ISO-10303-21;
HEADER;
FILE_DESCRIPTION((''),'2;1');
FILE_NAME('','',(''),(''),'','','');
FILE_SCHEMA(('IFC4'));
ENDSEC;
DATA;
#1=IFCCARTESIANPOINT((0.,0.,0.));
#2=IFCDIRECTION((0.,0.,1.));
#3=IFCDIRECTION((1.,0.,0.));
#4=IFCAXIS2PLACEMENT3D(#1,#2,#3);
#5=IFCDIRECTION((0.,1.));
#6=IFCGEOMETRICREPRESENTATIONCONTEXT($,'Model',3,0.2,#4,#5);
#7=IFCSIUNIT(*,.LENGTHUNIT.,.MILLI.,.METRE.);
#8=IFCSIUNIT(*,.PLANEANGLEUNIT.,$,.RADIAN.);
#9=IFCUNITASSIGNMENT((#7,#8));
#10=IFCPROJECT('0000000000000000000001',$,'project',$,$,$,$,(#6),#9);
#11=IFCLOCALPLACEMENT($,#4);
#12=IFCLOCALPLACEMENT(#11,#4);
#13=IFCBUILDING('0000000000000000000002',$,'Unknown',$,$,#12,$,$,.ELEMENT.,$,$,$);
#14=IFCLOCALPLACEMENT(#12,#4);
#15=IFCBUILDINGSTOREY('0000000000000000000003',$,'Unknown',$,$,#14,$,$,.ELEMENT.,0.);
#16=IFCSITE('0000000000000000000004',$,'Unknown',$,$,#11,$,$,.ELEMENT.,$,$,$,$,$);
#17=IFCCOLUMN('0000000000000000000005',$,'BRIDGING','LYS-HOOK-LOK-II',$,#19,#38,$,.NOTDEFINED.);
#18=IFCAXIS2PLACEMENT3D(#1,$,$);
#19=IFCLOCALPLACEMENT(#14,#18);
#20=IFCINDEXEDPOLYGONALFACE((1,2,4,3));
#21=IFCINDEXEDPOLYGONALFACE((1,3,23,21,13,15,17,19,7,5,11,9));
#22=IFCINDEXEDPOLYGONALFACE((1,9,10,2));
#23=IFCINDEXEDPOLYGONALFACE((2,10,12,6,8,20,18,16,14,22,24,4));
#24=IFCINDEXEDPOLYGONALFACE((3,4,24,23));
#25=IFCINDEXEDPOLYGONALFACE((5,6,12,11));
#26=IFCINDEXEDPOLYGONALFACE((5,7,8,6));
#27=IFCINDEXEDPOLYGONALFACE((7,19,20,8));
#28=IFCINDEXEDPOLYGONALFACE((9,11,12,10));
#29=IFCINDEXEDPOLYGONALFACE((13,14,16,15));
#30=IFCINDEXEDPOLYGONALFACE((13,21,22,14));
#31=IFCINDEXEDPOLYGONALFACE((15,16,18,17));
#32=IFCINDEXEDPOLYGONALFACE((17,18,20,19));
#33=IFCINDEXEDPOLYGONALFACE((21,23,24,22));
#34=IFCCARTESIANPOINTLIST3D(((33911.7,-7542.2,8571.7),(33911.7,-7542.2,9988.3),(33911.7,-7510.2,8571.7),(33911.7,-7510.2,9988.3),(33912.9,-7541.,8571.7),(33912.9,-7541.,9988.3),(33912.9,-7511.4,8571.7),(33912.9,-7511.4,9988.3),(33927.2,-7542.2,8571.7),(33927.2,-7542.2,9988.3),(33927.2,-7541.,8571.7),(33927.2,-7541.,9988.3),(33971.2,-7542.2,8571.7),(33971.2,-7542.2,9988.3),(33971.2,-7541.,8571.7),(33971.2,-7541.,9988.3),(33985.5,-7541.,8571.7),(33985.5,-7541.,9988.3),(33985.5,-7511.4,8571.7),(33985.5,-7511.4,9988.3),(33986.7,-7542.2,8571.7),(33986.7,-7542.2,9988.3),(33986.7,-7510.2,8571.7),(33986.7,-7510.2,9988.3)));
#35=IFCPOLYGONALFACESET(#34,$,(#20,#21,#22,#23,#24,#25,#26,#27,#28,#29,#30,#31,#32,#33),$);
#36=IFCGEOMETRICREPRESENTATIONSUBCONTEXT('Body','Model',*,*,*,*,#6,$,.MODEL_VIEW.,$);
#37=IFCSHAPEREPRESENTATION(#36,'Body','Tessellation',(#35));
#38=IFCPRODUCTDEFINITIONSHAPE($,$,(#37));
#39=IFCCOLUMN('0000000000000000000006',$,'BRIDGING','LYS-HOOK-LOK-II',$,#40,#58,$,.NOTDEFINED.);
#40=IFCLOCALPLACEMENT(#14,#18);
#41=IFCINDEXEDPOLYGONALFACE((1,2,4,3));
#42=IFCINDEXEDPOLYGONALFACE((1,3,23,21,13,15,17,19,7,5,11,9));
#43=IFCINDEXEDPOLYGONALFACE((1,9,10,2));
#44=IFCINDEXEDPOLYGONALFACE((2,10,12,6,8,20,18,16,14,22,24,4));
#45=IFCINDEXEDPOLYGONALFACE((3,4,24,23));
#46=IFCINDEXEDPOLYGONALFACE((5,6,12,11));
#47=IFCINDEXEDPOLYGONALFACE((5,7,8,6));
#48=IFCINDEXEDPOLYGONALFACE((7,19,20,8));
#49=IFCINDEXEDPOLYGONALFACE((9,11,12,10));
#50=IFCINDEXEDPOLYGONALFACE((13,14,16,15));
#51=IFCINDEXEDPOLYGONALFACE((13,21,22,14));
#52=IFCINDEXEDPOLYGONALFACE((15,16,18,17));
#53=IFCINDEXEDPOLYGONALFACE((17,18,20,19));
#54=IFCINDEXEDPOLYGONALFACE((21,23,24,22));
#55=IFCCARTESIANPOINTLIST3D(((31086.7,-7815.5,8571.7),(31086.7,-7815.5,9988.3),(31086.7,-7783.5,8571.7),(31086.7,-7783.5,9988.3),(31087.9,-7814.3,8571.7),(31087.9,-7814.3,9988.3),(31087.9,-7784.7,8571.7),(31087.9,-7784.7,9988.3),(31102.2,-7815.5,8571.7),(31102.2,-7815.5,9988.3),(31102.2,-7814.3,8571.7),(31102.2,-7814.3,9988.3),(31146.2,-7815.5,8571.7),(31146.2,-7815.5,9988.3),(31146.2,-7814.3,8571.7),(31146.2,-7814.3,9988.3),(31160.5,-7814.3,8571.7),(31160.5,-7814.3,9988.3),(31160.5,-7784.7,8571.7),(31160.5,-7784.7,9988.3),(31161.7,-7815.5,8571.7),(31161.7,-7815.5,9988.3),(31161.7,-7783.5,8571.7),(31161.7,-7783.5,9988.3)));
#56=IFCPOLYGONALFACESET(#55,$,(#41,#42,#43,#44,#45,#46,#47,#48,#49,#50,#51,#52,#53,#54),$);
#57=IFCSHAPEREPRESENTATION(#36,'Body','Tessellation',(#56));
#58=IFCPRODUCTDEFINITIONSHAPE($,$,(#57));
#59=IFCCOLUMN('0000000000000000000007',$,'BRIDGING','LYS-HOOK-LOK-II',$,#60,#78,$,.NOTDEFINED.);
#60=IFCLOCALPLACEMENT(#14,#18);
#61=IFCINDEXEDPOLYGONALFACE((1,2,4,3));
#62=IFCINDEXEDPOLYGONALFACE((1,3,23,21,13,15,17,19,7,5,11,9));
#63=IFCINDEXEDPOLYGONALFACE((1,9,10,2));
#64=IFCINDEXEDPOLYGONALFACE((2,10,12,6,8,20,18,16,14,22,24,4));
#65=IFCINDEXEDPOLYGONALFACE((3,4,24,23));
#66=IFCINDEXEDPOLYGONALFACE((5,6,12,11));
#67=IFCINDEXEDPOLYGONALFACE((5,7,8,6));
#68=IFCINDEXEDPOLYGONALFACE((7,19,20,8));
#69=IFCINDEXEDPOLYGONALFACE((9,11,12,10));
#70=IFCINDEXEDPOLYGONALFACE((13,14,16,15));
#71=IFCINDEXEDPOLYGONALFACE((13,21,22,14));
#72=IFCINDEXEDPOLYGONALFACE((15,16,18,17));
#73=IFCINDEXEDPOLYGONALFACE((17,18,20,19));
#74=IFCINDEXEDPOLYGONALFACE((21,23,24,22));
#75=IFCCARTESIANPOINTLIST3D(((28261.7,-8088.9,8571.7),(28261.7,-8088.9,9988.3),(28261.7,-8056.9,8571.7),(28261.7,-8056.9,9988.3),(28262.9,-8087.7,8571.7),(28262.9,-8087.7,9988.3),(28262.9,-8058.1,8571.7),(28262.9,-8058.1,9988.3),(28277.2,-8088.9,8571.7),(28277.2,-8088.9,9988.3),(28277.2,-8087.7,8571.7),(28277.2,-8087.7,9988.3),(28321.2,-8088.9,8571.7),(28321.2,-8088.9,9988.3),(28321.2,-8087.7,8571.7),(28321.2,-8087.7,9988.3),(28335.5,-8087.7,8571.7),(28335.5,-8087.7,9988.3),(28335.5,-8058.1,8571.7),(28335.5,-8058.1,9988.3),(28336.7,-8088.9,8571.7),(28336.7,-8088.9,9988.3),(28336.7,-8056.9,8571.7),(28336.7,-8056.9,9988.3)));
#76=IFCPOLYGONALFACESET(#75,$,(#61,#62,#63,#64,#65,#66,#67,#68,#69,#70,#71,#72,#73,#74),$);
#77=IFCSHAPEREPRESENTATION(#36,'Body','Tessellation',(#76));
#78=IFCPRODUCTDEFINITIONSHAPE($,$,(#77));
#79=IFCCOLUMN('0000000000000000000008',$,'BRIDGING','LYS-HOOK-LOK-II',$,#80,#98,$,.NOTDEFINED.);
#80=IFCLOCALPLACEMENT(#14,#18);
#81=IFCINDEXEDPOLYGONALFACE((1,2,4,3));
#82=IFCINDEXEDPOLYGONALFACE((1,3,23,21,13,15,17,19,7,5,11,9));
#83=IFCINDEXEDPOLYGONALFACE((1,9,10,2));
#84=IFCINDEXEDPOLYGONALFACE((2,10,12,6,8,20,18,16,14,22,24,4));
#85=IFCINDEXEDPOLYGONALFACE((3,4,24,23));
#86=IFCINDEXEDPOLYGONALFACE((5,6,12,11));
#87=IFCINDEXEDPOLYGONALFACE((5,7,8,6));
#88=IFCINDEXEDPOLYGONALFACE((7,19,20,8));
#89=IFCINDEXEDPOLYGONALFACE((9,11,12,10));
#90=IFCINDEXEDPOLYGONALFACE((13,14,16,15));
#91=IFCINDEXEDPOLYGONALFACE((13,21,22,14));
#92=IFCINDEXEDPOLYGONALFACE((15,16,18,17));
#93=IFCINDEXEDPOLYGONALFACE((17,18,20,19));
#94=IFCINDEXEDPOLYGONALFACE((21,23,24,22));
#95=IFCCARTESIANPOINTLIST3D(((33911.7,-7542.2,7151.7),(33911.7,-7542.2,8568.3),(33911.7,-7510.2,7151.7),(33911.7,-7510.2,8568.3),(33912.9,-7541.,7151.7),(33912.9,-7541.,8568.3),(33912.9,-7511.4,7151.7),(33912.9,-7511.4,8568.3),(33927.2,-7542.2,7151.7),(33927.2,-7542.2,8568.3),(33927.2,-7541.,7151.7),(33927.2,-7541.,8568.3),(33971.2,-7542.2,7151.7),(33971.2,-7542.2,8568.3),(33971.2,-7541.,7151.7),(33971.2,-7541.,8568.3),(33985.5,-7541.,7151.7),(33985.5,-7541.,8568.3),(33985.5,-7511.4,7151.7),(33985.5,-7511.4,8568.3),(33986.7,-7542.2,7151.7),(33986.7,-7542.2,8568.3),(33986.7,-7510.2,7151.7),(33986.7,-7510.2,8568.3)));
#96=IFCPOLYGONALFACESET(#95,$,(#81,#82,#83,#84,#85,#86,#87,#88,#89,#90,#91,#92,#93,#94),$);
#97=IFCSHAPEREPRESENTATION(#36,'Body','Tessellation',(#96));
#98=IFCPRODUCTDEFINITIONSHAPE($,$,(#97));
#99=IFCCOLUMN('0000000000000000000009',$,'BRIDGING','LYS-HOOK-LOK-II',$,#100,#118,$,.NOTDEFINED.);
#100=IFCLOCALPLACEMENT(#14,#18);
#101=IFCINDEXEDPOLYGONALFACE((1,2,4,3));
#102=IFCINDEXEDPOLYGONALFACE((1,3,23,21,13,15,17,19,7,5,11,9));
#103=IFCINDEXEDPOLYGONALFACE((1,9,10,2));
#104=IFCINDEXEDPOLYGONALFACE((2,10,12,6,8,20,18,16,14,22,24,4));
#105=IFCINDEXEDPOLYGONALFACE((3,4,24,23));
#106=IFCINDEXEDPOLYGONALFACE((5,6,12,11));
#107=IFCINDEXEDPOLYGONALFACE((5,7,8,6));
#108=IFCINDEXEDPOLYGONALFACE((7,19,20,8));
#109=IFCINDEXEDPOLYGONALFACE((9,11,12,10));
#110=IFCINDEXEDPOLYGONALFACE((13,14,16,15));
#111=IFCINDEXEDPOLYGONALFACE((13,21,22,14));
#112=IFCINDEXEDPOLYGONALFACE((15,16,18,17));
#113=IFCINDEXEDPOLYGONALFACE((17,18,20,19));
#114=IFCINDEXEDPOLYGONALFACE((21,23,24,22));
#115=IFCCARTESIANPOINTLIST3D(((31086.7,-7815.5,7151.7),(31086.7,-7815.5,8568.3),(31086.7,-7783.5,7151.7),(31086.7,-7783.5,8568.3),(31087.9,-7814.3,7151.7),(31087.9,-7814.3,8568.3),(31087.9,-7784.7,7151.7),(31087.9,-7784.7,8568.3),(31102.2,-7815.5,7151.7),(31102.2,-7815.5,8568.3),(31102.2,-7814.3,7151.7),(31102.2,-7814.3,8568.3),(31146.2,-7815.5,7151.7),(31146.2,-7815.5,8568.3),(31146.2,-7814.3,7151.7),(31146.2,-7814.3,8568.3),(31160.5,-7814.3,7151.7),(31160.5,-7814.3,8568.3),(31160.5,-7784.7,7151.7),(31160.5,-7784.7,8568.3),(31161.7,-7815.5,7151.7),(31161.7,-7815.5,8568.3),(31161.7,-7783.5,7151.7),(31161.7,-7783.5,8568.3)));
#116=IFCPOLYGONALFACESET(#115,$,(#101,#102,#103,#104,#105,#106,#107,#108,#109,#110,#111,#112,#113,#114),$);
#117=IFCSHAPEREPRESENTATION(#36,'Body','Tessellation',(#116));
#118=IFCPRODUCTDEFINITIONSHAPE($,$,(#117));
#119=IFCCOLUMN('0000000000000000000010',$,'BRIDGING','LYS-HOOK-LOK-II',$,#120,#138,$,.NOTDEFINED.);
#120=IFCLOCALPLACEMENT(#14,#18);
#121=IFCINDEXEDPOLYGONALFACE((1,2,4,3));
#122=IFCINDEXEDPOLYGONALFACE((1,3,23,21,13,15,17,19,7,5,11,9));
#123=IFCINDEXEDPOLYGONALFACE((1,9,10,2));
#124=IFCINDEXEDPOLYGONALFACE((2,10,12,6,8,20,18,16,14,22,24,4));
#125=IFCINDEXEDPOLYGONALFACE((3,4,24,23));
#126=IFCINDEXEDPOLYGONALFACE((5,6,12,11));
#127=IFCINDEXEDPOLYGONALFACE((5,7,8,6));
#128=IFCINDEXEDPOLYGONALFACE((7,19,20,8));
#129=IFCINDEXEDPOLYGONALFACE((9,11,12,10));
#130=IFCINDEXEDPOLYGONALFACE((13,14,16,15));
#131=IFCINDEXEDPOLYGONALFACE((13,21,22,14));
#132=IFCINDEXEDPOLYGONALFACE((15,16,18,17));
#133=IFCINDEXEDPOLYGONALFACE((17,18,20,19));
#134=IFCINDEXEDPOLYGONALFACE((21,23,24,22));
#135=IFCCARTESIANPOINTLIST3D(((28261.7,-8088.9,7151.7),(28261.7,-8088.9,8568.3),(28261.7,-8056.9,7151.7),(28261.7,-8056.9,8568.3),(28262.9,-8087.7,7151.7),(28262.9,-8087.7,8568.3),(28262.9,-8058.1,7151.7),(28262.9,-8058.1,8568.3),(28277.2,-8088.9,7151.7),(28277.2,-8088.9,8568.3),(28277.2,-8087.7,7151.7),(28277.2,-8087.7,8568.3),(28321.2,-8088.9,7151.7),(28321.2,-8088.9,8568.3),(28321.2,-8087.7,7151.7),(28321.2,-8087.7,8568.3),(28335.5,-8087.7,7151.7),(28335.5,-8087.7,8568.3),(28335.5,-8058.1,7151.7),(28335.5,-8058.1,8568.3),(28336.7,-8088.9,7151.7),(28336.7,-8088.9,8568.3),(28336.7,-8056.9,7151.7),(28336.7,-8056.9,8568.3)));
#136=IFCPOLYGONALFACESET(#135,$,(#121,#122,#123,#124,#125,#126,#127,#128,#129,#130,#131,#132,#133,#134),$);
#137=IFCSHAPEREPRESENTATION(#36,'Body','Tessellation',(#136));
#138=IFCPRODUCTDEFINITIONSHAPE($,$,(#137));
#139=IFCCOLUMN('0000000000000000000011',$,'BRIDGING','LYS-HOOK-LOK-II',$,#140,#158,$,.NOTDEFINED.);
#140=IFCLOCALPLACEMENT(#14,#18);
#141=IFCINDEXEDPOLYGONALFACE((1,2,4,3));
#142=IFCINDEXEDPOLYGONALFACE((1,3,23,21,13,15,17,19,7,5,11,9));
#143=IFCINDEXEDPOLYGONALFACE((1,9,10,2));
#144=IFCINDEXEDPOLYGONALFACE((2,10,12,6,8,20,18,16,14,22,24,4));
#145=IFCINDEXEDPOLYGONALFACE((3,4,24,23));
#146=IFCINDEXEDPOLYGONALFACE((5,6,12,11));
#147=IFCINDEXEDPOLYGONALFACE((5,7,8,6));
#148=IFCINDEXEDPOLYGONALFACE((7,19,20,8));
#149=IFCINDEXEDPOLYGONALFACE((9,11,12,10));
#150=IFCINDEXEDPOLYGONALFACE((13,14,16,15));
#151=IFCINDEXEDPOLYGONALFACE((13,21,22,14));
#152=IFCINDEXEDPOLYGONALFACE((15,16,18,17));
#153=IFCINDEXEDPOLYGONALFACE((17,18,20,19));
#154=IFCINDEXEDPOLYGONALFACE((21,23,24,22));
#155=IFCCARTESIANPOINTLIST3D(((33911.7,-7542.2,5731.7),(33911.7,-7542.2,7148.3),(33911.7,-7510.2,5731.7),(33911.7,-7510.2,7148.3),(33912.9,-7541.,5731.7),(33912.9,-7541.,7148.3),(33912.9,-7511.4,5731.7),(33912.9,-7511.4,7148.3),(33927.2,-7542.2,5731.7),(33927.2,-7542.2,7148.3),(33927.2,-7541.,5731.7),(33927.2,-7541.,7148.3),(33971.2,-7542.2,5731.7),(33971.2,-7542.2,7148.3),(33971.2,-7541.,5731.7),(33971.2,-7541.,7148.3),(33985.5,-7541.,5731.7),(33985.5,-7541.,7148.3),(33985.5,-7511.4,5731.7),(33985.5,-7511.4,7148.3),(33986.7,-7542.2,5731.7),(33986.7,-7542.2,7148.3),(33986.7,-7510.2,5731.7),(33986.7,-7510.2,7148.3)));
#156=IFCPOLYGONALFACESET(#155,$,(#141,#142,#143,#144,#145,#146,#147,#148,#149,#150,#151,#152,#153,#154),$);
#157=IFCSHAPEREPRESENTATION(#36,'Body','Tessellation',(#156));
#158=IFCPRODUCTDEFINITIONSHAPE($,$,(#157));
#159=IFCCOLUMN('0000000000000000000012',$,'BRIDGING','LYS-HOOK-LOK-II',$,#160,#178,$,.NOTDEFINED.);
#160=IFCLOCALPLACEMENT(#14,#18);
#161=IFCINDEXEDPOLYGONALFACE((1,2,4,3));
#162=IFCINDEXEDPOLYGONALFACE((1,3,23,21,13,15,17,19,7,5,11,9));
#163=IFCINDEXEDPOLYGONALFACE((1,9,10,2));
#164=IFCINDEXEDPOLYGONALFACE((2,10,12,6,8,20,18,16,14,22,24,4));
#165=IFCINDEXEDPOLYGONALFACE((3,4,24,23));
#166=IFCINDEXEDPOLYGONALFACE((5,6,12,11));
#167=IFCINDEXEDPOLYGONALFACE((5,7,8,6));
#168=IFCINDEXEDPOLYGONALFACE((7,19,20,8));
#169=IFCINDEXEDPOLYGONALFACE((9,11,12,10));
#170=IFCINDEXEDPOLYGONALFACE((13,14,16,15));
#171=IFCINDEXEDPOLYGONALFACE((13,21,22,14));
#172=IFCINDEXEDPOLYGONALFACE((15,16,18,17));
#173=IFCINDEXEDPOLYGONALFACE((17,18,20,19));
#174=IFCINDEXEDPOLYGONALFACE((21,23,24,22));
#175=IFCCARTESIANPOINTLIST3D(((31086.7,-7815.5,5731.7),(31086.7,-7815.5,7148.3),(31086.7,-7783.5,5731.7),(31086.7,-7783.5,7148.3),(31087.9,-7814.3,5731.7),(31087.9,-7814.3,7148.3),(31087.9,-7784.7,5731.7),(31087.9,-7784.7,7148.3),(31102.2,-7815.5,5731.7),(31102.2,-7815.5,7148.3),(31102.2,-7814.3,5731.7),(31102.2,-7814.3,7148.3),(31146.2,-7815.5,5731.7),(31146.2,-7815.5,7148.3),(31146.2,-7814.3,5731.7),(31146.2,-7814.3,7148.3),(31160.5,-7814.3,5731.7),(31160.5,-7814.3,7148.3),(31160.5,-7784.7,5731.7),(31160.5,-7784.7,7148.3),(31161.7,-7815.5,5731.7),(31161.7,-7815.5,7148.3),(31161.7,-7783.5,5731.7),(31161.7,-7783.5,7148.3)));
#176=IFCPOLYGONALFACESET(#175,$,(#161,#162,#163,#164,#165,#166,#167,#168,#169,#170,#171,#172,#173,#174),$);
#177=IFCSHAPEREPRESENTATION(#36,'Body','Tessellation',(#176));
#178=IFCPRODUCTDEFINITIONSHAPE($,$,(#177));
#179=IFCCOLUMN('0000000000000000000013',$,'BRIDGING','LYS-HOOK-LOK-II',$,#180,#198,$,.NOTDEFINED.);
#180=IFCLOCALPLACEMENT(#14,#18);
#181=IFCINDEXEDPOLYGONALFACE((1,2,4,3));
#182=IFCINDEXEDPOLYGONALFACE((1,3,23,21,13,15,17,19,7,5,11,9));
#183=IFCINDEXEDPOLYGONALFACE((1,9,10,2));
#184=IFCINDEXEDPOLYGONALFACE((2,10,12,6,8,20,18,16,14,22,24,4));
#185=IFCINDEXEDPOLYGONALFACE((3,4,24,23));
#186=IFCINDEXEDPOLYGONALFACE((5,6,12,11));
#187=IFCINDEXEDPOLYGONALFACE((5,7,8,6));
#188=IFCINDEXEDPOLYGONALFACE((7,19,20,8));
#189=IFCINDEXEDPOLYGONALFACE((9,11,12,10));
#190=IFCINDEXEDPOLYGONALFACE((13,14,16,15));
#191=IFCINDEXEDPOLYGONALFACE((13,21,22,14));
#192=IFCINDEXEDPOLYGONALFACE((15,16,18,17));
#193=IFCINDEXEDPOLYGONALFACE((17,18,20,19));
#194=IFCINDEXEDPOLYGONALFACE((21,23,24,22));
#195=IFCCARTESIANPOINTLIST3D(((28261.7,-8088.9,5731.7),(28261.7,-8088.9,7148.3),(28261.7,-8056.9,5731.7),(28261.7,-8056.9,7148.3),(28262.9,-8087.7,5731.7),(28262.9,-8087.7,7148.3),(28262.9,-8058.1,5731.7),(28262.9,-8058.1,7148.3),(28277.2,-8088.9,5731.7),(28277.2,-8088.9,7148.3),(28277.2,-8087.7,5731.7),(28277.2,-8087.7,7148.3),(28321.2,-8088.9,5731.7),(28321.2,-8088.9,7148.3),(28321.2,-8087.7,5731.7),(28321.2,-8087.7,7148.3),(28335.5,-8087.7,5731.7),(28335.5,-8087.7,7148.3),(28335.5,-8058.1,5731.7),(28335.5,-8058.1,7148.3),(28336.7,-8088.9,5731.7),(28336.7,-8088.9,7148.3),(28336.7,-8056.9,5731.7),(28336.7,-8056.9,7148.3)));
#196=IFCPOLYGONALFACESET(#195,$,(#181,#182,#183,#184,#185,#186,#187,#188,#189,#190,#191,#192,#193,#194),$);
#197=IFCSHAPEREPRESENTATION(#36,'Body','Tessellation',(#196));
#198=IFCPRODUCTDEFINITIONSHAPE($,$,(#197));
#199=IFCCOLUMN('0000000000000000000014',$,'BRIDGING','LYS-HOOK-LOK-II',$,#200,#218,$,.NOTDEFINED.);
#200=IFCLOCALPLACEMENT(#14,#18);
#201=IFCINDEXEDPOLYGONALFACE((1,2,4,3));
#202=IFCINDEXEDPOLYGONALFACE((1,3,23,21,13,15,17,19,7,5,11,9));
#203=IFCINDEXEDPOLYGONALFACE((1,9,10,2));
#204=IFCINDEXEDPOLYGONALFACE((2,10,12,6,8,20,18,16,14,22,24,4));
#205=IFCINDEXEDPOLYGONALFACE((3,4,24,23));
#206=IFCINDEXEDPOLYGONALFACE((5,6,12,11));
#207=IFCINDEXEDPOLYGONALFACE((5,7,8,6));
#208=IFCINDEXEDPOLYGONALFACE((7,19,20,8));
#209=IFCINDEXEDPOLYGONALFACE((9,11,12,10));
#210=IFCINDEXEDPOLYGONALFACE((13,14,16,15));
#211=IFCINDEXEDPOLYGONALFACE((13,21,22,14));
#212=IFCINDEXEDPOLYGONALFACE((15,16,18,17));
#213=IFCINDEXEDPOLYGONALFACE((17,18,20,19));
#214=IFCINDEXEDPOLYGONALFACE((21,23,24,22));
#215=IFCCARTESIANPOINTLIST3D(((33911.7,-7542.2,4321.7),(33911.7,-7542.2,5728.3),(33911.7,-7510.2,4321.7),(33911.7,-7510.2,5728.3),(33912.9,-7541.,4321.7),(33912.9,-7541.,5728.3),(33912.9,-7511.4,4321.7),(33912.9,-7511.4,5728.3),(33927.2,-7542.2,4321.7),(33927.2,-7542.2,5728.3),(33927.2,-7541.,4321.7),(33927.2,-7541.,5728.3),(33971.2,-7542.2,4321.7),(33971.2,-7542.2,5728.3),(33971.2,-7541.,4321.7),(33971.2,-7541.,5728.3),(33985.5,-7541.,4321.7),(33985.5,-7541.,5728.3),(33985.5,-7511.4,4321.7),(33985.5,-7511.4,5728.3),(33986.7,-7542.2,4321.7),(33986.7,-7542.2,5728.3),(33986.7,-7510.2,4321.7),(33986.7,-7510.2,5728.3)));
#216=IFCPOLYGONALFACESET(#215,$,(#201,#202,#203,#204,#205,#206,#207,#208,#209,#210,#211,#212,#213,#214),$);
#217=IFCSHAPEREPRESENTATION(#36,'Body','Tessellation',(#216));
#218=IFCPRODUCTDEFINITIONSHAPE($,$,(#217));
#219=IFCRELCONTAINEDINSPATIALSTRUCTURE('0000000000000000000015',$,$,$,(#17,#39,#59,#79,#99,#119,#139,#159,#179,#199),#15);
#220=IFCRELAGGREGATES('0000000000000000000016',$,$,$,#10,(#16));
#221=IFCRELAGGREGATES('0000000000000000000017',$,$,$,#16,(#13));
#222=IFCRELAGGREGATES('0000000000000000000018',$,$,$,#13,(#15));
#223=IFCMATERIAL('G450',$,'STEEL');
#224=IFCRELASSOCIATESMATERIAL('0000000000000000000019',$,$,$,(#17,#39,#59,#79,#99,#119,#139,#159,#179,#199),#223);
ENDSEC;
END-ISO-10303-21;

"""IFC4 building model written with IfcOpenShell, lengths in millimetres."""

from ifc_helpers import new_model, si_unit, direction, frame, origin_with_axes, place, context, subcontext, project, spatial, line, indexed_curve, outline, extrude, material, element, save


model = new_model("IFC4")

# Units and contexts
model_context = context("Model", 3, precision=0.2, world=origin_with_axes(), true_north=direction((0.0, 1.0)))
body_context = subcontext(model_context, "Body", "Model", "MODEL_VIEW")
ifc_project = project(units=[si_unit("LENGTHUNIT", "METRE", prefix="MILLI"), si_unit("PLANEANGLEUNIT", "RADIAN")], contexts=[model_context])

# Site, building, storey
site_placement = place(None, origin_with_axes())
site = spatial("IfcSite", under=ifc_project, at=site_placement, Name="Unknown", CompositionType="ELEMENT")
building_placement = place(site_placement, origin_with_axes())
building = spatial("IfcBuilding", under=site, at=building_placement, Name="Unknown", CompositionType="ELEMENT")
storey_placement = place(building_placement, origin_with_axes())
storey = spatial("IfcBuildingStorey", under=building, at=storey_placement, Name="Unknown", CompositionType="ELEMENT", Elevation=0.0)

# Columns
ifc_material_1 = material(Name="G450", Category="STEEL")
for number, where, z_axis, x_axis, name in (
    (1, (33949.2, -7526.2, 8571.7), (0.0, -1.0, 0.0), (0.0, 0.0, 1.0), "BRIDGING"),
    (2, (31124.2, -7799.5, 8571.7), (0.0, -1.0, 0.0), (0.0, 0.0, 1.0), "BRIDGING"),
    (3, (28299.2, -8072.9, 8571.7), (0.0, -1.0, 0.0), (0.0, 0.0, 1.0), "BRIDGING"),
    (4, (33949.2, -7526.2, 7151.7), (0.0, -1.0, 0.0), (0.0, 0.0, 1.0), "BRIDGING"),
    (5, (31124.2, -7799.5, 7151.7), (0.0, -1.0, 0.0), (0.0, 0.0, 1.0), "BRIDGING"),
    (6, (28299.2, -8072.9, 7151.7), (0.0, -1.0, 0.0), (0.0, 0.0, 1.0), "BRIDGING"),
    (7, (33949.2, -7526.2, 5731.7), (0.0, -1.0, 0.0), (0.0, 0.0, 1.0), "BRIDGING"),
    (8, (31124.2, -7799.5, 5731.7), (0.0, -1.0, 0.0), (0.0, 0.0, 1.0), "BRIDGING"),
    (9, (28299.2, -8072.9, 5731.7), (0.0, -1.0, 0.0), (0.0, 0.0, 1.0), "BRIDGING"),
):
    element("IfcColumn", number, at=place(storey_placement, frame(where, z_axis=z_axis, x_axis=x_axis)), inside=storey, material=ifc_material_1, Name=name, Description="LYS-HOOK-LOK-II", PredefinedType="NOTDEFINED", context=body_context, shape_type="SolidModel", body=[
        extrude(outline(indexed_curve([(16.0, -37.5), (16.0, -22.0), (14.8, -22.0), (14.8, -36.3), (-14.8, -36.3), (-14.8, 36.3), (14.8, 36.3), (14.8, 22.0), (16.0, 22.0), (16.0, 37.5), (-16.0, 37.5), (-16.0, -37.5)], segments=[line(1, 2, 3, 4, 5, 6, 7, 8, 9, 10, 11, 12, 1)])), frame((0.0, 0.0, 0.0), z_axis=(-1.0, 0.0, 0.0), x_axis=(0.0, 0.0, 1.0)), (0.0, 0.0, -1.0), 1416.6),
    ])
for number, where, z_axis, x_axis, name in (
    (10, (33949.2, -7526.2, 4321.7), (0.0, -1.0, 0.0), (0.0, 0.0, 1.0), "BRIDGING"),
):
    element("IfcColumn", number, at=place(storey_placement, frame(where, z_axis=z_axis, x_axis=x_axis)), inside=storey, material=ifc_material_1, Name=name, Description="LYS-HOOK-LOK-II", PredefinedType="NOTDEFINED", context=body_context, shape_type="SolidModel", body=[
        extrude(outline(indexed_curve([(16.0, -37.5), (16.0, -22.0), (14.8, -22.0), (14.8, -36.3), (-14.8, -36.3), (-14.8, 36.3), (14.8, 36.3), (14.8, 22.0), (16.0, 22.0), (16.0, 37.5), (-16.0, 37.5), (-16.0, -37.5)], segments=[line(1, 2, 3, 4, 5, 6, 7, 8, 9, 10, 11, 12, 1)])), frame((0.0, 0.0, 0.0), z_axis=(-1.0, 0.0, 0.0), x_axis=(0.0, 0.0, 1.0)), (0.0, 0.0, -1.0), 1406.6),
    ])

save(model, "model.ifc")
